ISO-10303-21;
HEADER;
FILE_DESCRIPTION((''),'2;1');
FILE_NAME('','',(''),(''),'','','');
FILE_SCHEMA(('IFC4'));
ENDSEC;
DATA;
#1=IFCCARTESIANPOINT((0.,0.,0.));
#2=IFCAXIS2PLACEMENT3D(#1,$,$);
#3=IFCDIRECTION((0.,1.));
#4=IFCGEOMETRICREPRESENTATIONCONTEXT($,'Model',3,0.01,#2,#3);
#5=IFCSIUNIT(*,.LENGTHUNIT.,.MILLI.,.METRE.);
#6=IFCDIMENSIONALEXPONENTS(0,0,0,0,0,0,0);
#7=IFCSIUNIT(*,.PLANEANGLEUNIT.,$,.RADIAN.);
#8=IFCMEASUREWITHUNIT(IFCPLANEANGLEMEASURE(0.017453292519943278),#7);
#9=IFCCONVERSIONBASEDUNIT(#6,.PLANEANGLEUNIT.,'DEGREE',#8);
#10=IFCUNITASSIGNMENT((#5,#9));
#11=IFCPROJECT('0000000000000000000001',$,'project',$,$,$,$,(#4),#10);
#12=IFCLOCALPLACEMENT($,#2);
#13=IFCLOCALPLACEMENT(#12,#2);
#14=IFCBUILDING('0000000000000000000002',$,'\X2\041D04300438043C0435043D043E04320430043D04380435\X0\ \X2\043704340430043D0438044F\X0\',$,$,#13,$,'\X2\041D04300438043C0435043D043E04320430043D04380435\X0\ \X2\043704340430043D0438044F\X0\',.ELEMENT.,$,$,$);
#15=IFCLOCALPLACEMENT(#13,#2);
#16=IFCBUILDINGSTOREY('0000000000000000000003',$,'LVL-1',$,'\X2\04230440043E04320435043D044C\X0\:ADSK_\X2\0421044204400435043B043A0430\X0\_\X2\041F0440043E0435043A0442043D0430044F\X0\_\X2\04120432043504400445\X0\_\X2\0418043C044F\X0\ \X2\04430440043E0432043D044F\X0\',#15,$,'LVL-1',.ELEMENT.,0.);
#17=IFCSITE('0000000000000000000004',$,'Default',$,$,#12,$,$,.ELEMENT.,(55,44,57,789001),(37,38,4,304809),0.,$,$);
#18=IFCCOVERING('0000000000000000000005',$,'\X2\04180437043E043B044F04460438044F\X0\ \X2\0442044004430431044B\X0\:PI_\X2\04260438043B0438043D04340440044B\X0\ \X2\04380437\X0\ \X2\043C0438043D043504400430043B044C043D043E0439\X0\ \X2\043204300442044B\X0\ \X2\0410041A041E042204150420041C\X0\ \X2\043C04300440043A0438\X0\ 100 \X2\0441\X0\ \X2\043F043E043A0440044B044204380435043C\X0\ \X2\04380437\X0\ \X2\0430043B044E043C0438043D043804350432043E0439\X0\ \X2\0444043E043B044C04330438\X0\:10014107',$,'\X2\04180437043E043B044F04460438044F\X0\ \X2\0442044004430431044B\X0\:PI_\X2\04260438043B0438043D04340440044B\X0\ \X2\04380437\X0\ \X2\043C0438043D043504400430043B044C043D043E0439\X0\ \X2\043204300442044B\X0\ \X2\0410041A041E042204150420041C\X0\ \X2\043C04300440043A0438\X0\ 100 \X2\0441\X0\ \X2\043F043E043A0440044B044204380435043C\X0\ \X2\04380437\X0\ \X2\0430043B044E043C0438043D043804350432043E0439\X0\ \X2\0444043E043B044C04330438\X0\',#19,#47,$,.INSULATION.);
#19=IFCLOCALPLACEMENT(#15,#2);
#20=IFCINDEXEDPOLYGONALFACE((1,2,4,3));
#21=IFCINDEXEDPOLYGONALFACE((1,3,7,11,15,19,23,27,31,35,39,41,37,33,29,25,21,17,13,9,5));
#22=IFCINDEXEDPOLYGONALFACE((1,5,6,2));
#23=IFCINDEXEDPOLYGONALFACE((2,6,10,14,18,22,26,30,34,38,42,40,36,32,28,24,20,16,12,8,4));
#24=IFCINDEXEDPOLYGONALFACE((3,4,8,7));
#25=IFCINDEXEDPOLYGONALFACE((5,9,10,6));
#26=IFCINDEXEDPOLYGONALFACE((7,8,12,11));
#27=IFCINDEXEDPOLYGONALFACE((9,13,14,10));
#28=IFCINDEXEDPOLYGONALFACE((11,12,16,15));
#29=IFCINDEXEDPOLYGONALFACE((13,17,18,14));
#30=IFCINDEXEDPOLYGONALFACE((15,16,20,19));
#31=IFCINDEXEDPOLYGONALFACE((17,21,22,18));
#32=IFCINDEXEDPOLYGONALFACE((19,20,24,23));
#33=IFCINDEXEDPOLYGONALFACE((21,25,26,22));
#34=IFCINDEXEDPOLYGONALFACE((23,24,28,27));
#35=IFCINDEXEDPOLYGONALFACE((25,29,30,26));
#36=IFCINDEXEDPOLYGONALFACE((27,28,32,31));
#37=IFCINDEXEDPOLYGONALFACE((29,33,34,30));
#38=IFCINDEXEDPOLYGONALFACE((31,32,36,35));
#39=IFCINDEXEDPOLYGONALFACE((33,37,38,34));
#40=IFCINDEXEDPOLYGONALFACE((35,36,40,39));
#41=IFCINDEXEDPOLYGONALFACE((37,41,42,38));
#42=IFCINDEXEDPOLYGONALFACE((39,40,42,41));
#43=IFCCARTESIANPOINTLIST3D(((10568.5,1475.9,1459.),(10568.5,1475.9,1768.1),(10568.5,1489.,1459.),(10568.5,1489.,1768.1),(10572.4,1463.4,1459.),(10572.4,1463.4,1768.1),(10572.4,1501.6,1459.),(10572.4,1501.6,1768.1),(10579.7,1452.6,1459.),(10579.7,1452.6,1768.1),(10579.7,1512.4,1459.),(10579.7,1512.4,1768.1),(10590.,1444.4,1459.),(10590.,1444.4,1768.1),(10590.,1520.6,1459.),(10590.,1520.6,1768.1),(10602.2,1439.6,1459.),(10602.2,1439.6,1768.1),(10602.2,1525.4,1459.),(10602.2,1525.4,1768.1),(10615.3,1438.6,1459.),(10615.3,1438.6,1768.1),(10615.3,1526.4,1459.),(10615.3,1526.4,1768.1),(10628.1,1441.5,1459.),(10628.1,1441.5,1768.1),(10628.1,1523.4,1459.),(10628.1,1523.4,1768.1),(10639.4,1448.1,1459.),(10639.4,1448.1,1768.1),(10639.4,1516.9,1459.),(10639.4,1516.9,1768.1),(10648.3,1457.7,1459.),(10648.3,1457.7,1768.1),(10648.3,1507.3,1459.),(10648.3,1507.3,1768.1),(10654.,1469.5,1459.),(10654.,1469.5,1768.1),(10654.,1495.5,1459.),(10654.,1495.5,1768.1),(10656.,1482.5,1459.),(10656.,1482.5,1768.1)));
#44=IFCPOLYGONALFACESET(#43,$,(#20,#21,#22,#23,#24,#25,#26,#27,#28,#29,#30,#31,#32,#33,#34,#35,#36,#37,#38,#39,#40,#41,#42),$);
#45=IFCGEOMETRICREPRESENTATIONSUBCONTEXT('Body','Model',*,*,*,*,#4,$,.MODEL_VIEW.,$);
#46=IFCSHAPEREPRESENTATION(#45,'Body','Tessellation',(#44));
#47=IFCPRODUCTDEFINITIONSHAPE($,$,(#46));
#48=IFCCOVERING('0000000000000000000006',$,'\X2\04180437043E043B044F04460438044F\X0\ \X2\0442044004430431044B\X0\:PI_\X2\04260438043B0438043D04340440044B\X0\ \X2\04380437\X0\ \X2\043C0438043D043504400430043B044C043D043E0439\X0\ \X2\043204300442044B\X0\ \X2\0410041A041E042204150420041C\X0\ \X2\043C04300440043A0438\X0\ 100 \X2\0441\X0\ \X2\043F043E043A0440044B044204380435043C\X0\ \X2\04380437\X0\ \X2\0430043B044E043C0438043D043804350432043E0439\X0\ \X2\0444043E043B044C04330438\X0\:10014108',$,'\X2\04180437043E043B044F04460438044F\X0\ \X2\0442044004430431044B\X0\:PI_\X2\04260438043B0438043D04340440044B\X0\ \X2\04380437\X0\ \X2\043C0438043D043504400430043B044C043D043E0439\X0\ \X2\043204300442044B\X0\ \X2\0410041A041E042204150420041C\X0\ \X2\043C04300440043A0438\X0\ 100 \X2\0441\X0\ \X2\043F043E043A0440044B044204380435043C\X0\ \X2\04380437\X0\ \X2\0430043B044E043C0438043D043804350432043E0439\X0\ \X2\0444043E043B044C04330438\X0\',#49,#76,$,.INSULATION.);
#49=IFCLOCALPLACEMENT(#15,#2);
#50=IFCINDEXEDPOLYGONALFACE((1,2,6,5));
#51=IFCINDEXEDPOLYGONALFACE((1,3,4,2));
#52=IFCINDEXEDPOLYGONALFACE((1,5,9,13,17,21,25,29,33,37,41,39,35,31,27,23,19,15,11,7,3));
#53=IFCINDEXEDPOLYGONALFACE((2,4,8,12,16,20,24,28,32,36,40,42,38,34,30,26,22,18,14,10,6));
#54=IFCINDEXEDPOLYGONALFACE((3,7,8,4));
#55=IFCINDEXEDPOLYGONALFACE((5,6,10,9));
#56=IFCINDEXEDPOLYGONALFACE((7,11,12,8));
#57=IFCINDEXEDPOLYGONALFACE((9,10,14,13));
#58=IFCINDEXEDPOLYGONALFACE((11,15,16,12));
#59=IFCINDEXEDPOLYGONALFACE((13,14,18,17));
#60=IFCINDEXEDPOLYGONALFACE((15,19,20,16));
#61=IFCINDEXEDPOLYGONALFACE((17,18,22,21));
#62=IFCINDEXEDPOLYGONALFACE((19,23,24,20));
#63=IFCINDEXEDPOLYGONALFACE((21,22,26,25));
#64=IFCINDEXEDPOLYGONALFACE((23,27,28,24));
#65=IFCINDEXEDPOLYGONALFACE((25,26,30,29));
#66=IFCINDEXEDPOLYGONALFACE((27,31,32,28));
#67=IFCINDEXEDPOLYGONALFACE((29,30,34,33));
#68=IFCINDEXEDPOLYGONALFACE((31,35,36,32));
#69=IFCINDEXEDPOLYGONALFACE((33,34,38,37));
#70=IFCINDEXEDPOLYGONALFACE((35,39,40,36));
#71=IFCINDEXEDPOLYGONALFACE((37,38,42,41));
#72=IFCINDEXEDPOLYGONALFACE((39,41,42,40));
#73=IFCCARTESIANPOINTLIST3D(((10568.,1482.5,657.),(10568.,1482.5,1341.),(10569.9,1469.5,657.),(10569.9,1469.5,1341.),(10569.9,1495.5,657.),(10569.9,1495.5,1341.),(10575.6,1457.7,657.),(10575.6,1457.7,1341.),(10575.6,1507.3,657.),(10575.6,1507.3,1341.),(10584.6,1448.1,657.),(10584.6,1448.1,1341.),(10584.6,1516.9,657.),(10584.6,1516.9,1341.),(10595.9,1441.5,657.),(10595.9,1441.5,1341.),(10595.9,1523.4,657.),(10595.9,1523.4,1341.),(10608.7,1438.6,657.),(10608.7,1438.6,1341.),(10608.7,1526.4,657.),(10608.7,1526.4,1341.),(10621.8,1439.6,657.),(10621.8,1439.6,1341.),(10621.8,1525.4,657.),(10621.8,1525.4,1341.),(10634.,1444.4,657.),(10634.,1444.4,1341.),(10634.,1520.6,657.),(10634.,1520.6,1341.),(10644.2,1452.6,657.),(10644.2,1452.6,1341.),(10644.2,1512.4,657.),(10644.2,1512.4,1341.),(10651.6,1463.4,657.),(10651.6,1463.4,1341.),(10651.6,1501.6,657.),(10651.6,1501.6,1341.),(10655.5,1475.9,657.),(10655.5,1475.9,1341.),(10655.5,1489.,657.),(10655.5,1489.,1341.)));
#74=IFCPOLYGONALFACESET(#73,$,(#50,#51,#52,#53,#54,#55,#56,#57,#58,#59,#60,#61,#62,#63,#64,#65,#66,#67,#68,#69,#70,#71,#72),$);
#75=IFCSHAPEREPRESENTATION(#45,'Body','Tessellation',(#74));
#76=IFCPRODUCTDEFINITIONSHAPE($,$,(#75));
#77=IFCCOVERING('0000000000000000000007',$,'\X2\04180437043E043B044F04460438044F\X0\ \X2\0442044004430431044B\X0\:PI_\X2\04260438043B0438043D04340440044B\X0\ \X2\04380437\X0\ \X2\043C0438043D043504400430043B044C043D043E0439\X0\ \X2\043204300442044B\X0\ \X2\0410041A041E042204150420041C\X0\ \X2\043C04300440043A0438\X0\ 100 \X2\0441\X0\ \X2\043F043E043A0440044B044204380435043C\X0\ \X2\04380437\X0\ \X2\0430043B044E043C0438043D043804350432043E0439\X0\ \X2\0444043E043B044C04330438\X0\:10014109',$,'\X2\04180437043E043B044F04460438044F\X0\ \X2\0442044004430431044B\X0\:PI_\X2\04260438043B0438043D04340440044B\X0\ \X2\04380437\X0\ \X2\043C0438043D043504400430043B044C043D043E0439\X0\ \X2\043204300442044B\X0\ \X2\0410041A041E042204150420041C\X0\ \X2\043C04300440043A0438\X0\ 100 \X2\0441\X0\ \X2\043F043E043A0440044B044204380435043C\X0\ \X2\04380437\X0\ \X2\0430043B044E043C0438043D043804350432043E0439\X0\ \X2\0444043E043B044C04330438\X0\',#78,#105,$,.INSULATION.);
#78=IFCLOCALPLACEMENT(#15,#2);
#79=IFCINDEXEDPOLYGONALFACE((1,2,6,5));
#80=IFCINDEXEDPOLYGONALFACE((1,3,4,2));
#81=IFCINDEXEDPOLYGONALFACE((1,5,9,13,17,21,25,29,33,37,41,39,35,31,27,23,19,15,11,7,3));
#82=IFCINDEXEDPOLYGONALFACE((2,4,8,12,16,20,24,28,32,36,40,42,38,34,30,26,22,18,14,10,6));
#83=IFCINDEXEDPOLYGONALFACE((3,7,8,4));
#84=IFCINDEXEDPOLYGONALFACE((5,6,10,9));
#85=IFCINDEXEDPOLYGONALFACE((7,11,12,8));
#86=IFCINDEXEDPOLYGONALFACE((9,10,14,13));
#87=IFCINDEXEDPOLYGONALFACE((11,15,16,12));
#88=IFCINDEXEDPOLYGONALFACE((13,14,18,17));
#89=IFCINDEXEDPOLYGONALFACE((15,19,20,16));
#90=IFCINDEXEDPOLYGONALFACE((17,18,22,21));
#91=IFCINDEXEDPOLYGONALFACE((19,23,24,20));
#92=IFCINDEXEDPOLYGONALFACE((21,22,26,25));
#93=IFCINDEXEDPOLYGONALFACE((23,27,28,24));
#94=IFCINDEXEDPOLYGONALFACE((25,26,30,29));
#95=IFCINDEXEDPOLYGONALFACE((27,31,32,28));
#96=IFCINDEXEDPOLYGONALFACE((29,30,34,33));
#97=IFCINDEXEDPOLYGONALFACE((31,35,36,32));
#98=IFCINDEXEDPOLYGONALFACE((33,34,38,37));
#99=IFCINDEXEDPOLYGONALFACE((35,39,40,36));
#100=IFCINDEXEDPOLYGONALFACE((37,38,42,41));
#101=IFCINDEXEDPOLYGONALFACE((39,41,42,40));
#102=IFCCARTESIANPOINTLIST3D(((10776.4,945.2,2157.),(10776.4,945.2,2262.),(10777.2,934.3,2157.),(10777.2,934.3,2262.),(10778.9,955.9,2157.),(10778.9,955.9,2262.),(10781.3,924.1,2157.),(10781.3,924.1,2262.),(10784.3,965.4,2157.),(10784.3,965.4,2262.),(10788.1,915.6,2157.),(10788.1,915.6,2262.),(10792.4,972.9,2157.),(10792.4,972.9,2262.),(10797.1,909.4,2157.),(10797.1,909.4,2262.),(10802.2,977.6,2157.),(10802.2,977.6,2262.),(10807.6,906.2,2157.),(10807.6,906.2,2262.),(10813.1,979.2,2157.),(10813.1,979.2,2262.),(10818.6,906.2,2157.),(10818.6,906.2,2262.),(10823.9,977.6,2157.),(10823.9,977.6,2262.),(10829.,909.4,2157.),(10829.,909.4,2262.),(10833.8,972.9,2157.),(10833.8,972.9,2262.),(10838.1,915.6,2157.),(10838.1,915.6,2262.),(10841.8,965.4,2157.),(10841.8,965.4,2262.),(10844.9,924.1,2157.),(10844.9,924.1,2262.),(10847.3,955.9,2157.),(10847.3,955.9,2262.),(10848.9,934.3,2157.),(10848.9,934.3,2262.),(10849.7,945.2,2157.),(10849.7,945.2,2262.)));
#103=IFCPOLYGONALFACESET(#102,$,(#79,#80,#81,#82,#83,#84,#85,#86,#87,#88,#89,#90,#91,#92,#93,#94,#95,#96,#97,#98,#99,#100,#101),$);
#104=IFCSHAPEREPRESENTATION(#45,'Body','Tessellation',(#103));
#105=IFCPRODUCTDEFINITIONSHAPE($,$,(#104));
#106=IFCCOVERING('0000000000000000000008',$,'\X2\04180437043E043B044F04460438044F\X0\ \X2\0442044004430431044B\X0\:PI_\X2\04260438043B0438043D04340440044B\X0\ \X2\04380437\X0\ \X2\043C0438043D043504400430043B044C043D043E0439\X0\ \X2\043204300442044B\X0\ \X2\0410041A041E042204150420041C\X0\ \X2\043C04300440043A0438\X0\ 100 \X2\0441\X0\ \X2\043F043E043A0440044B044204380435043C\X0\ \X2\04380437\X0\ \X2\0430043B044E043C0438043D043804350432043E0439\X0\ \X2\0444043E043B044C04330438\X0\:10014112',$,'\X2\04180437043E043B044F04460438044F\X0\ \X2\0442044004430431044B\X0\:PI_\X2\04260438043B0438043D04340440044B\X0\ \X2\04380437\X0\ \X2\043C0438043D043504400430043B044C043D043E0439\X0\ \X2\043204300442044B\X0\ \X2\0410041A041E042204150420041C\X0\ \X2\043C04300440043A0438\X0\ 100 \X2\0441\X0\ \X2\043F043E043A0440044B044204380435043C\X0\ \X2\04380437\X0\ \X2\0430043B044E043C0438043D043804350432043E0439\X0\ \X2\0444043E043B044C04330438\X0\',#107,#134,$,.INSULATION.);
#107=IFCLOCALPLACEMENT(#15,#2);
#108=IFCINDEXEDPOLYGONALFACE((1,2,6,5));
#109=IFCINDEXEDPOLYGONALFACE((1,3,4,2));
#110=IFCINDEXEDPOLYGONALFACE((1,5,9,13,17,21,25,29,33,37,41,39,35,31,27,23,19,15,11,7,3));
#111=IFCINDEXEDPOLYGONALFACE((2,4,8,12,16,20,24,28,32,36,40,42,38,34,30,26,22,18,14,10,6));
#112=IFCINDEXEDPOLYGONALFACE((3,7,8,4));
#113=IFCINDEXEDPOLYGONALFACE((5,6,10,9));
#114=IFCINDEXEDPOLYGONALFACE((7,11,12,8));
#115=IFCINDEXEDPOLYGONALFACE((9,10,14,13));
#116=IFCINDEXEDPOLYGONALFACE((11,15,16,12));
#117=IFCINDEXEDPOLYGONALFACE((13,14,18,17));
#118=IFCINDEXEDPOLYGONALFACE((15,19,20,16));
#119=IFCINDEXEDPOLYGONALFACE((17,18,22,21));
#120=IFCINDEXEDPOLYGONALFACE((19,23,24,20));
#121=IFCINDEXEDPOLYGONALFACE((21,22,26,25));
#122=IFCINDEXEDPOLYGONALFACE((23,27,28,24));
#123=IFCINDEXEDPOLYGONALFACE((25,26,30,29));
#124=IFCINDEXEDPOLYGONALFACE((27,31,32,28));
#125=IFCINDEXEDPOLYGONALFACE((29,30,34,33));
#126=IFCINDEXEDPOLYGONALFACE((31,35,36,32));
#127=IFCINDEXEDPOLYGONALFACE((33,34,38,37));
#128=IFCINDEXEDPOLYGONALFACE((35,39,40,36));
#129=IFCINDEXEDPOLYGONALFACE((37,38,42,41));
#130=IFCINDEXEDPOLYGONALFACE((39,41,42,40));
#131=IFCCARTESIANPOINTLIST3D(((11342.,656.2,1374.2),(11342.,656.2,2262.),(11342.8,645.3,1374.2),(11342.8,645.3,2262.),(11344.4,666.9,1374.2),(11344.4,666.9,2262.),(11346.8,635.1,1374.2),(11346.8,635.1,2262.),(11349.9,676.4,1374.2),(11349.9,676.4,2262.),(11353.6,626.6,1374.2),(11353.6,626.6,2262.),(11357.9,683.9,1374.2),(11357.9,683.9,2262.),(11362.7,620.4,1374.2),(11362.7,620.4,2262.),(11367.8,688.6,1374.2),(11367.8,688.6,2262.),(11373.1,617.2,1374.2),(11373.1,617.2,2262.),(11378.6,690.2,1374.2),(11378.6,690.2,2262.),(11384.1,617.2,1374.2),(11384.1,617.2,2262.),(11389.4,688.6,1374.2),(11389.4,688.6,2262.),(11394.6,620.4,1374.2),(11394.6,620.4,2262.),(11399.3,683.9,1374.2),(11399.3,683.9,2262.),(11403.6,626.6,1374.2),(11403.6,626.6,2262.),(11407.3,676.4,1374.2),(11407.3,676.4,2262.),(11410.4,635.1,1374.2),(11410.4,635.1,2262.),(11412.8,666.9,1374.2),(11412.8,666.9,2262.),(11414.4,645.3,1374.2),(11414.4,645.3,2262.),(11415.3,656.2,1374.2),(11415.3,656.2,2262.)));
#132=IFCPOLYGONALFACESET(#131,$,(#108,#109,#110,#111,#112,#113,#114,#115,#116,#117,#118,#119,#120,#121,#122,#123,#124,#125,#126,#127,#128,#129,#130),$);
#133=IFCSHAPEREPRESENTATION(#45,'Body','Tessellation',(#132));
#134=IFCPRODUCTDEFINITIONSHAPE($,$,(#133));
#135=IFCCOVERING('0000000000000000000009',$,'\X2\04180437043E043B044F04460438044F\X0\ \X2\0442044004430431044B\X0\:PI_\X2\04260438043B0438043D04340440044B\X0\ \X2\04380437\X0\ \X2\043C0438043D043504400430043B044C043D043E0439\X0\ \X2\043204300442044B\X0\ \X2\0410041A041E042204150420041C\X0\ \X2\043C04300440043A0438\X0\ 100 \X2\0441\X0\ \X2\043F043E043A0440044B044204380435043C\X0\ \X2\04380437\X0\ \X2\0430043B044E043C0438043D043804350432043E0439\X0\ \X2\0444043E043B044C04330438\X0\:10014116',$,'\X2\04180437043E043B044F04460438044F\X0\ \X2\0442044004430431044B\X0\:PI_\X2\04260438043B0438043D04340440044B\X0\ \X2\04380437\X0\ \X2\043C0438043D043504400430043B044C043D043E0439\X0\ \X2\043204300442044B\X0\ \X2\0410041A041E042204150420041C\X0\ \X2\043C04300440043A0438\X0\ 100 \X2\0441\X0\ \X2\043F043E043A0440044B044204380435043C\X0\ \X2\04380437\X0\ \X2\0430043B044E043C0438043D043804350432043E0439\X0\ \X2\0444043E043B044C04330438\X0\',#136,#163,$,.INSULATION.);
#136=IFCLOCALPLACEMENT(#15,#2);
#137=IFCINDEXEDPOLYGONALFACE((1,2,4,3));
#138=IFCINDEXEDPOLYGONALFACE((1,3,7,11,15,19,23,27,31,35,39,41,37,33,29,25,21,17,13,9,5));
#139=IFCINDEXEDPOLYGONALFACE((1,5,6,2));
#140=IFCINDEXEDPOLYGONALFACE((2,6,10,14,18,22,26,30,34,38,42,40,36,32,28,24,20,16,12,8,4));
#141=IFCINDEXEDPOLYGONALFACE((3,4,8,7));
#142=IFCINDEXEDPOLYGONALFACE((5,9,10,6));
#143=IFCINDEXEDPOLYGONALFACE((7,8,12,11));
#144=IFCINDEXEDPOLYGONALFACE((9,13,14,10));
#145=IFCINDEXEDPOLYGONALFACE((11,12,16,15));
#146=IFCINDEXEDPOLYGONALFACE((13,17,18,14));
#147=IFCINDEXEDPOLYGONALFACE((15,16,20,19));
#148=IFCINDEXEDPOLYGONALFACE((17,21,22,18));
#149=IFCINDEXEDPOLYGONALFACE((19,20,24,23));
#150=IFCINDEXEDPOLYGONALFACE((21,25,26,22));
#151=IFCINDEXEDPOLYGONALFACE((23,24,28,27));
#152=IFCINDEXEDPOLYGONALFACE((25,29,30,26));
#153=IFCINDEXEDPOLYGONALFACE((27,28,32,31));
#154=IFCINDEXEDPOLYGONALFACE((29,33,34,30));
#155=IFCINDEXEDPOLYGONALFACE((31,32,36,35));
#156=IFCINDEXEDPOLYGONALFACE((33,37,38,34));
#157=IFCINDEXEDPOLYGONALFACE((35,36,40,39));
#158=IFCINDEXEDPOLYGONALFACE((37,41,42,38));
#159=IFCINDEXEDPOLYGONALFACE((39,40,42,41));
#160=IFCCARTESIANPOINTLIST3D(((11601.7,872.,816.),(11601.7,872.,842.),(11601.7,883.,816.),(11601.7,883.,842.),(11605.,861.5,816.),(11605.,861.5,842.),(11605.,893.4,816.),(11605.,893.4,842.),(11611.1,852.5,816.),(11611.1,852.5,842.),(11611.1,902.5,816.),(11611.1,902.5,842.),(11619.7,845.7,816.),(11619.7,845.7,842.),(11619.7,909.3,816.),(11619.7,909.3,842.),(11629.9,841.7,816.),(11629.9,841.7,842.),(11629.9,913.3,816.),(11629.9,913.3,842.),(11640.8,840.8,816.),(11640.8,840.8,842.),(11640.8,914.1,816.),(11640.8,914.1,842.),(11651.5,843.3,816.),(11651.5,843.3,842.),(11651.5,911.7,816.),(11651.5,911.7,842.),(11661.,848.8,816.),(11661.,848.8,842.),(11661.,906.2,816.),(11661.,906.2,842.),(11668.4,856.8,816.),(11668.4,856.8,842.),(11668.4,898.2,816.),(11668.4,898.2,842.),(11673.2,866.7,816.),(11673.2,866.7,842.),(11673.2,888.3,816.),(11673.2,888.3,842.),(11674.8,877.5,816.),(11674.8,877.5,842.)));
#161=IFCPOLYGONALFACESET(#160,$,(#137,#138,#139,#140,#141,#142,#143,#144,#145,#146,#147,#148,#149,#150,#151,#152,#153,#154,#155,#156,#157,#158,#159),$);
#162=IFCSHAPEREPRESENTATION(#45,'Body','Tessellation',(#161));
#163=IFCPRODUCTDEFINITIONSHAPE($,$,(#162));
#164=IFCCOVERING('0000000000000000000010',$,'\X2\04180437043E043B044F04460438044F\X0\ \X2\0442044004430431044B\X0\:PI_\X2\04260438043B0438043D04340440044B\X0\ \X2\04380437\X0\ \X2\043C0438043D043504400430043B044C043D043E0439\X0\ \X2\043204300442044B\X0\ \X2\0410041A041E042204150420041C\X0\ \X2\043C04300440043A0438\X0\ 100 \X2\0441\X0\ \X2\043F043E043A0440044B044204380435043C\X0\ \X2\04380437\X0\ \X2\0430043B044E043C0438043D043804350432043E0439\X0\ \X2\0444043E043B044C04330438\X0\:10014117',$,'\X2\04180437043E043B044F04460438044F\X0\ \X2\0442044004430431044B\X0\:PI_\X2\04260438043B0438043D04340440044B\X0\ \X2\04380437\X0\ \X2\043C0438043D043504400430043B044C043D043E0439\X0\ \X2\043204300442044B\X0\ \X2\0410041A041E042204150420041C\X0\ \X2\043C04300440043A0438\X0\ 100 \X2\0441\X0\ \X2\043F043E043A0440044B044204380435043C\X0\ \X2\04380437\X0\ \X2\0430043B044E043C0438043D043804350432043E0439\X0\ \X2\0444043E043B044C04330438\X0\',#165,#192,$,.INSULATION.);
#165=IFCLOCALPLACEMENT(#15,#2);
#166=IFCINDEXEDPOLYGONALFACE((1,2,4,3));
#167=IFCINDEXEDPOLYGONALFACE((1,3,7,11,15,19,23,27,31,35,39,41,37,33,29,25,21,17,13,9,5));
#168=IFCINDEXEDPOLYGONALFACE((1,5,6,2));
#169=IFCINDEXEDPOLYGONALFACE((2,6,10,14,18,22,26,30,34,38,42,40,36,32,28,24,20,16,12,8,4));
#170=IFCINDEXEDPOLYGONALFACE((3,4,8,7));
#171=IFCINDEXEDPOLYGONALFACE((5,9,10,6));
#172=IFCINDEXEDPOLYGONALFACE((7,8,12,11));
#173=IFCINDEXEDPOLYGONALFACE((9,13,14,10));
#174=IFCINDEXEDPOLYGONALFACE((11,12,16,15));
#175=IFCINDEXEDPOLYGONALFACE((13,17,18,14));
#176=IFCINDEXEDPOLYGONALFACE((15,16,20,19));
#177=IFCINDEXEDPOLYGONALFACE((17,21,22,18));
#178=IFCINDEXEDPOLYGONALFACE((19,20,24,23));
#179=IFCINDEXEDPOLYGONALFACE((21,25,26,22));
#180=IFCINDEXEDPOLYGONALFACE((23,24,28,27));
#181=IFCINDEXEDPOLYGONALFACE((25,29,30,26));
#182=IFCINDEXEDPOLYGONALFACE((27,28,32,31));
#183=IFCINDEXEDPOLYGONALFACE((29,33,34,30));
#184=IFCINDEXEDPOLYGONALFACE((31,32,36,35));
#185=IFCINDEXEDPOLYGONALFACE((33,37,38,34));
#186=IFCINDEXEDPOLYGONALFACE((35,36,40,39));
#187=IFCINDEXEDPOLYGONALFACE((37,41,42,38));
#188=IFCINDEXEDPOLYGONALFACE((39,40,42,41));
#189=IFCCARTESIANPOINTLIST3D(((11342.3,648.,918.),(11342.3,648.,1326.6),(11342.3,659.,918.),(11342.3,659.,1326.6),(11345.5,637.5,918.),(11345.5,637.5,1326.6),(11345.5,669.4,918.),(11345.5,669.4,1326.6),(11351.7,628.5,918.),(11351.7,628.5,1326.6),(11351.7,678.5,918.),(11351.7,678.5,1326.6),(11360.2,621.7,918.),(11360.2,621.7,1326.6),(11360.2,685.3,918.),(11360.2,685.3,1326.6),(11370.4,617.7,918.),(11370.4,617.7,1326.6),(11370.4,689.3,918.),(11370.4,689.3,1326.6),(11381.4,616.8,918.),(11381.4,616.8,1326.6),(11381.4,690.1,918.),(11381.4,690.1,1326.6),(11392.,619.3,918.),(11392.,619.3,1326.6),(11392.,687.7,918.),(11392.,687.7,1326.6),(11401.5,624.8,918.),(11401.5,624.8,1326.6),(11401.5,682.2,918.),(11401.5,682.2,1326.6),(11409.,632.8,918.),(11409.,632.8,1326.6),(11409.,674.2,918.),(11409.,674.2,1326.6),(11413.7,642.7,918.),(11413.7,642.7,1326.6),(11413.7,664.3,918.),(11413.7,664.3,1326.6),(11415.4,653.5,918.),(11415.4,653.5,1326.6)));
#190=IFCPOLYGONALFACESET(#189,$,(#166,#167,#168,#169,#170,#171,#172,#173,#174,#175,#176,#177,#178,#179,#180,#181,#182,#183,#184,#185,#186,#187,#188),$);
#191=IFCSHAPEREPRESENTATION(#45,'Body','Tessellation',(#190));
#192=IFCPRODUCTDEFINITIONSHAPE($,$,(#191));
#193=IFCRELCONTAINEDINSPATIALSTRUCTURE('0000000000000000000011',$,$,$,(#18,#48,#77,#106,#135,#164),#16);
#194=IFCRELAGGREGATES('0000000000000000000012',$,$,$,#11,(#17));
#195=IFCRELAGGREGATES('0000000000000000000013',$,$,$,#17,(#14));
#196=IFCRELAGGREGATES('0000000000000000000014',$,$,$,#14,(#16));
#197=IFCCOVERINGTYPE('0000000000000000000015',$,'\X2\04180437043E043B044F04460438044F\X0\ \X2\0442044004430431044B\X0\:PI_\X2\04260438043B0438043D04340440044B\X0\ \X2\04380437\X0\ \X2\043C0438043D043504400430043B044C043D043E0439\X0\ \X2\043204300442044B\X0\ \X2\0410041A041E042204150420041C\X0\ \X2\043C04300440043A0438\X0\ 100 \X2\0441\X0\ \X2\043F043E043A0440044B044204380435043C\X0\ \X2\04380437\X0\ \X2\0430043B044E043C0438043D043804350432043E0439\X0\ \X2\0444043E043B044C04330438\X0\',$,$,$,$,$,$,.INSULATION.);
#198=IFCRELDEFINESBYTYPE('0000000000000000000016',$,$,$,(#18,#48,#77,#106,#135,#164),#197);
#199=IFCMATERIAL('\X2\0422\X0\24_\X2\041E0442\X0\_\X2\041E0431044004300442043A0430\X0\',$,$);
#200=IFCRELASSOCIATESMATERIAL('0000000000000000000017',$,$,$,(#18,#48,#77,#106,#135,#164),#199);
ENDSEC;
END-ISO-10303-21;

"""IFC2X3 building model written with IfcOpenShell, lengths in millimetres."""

from ifc_helpers import new_model, entity, si_unit, converted_unit, direction, frame, frame_2d, origin, origin_2d_with_axis, place, context, subcontext, project, spatial, circle, extrude, material, type_object, element, save


model = new_model("IFC2X3")

# Units and contexts
model_context = context("Model", 3, precision=0.01, world=origin(), true_north=direction((0.0, 1.0)))
body_context = subcontext(model_context, "Body", "Model", "MODEL_VIEW")
ifc_project = project(units=[si_unit("LENGTHUNIT", "METRE", prefix="MILLI"), converted_unit("PLANEANGLEUNIT", "DEGREE", entity("IfcPlaneAngleMeasure", 0.017453292519943278), si_unit("PLANEANGLEUNIT", "RADIAN"), dimensions=[0, 0, 0, 0, 0, 0, 0])], contexts=[model_context])

# Site, building, storey
site_placement = place(None, origin())
site = spatial("IfcSite", under=ifc_project, at=site_placement, Name="Default", CompositionType="ELEMENT", RefLatitude=(55, 44, 57, 789001), RefLongitude=(37, 38, 4, 304809), RefElevation=0.0)
building_placement = place(site_placement, origin())
building = spatial("IfcBuilding", under=site, at=building_placement, Name="Наименование здания", LongName="Наименование здания", CompositionType="ELEMENT")
storey_placement = place(building_placement, origin())
storey = spatial("IfcBuildingStorey", under=building, at=storey_placement, Name="LVL-1", ObjectType="Уровень:ADSK_Стрелка_Проектная_Вверх_Имя уровня", LongName="LVL-1", CompositionType="ELEMENT", Elevation=0.0)

# Coverings
covering_type = type_object("IfcCoveringType", Name="Изоляция трубы:PI_Цилиндры из минеральной ваты АКОТЕРМ марки 100 с покрытием из алюминиевой фольги", PredefinedType="INSULATION")
ifc_material_1 = material(Name="Т24_От_Обратка")
covering_1_placement = place(storey_placement, origin())
element("IfcCovering", 1, at=covering_1_placement, inside=storey, type_object=covering_type, material=ifc_material_1, Name="Изоляция трубы:PI_Цилиндры из минеральной ваты АКОТЕРМ марки 100 с покрытием из алюминиевой фольги:10014107", ObjectType="Изоляция трубы:PI_Цилиндры из минеральной ваты АКОТЕРМ марки 100 с покрытием из алюминиевой фольги", PredefinedType="INSULATION", context=body_context, shape_type="SweptSolid", body=[
    extrude(circle(Radius=44.0, at=frame_2d((0.0, 0.0), x_axis=(1.0, 0.0))), frame((10612.0, 1482.5, 1459.0)), (0.0, 0.0, 1.0), 309.1),
])
covering_2_placement = place(storey_placement, origin())
element("IfcCovering", 2, at=covering_2_placement, inside=storey, type_object=covering_type, material=ifc_material_1, Name="Изоляция трубы:PI_Цилиндры из минеральной ваты АКОТЕРМ марки 100 с покрытием из алюминиевой фольги:10014108", ObjectType="Изоляция трубы:PI_Цилиндры из минеральной ваты АКОТЕРМ марки 100 с покрытием из алюминиевой фольги", PredefinedType="INSULATION", context=body_context, shape_type="SweptSolid", body=[
    extrude(circle(Radius=44.0, at=frame_2d((0.0, 0.0), x_axis=(1.0, 0.0))), frame((10612.0, 1482.5, 657.0), z_axis=(0.0, 0.0, 1.0), x_axis=(-1.0, 0.0, 0.0)), (0.0, 0.0, 1.0), 684.0),
])
covering_3_placement = place(storey_placement, origin())
element("IfcCovering", 3, at=covering_3_placement, inside=storey, type_object=covering_type, material=ifc_material_1, Name="Изоляция трубы:PI_Цилиндры из минеральной ваты АКОТЕРМ марки 100 с покрытием из алюминиевой фольги:10014109", ObjectType="Изоляция трубы:PI_Цилиндры из минеральной ваты АКОТЕРМ марки 100 с покрытием из алюминиевой фольги", PredefinedType="INSULATION", context=body_context, shape_type="SweptSolid", body=[
    extrude(circle(Radius=36.8, at=frame_2d((0.0, 0.0), x_axis=(1.0, 0.0))), frame((10813.1, 942.5, 2157.0), z_axis=(0.0, 0.0, 1.0), x_axis=(0.0, 1.0, 0.0)), (0.0, 0.0, 1.0), 105.0),
])
covering_4_placement = place(storey_placement, origin())
element("IfcCovering", 4, at=covering_4_placement, inside=storey, type_object=covering_type, material=ifc_material_1, Name="Изоляция трубы:PI_Цилиндры из минеральной ваты АКОТЕРМ марки 100 с покрытием из алюминиевой фольги:10014112", ObjectType="Изоляция трубы:PI_Цилиндры из минеральной ваты АКОТЕРМ марки 100 с покрытием из алюминиевой фольги", PredefinedType="INSULATION", context=body_context, shape_type="SweptSolid", body=[
    extrude(circle(Radius=36.8, at=frame_2d((0.0, 0.0), x_axis=(1.0, 0.0))), frame((11378.6, 653.5, 1374.2), z_axis=(0.0, 0.0, 1.0), x_axis=(0.0, 1.0, 0.0)), (0.0, 0.0, 1.0), 887.7),
])
covering_5_placement = place(storey_placement, origin())
element("IfcCovering", 5, at=covering_5_placement, inside=storey, type_object=covering_type, material=ifc_material_1, Name="Изоляция трубы:PI_Цилиндры из минеральной ваты АКОТЕРМ марки 100 с покрытием из алюминиевой фольги:10014116", ObjectType="Изоляция трубы:PI_Цилиндры из минеральной ваты АКОТЕРМ марки 100 с покрытием из алюминиевой фольги", PredefinedType="INSULATION", context=body_context, shape_type="SweptSolid", body=[
    extrude(circle(Radius=36.8, at=origin_2d_with_axis()), frame((11638.1, 877.5, 816.0)), (0.0, 0.0, 1.0), 26.0),
])
covering_6_placement = place(storey_placement, origin())
element("IfcCovering", 6, at=covering_6_placement, inside=storey, type_object=covering_type, material=ifc_material_1, Name="Изоляция трубы:PI_Цилиндры из минеральной ваты АКОТЕРМ марки 100 с покрытием из алюминиевой фольги:10014117", ObjectType="Изоляция трубы:PI_Цилиндры из минеральной ваты АКОТЕРМ марки 100 с покрытием из алюминиевой фольги", PredefinedType="INSULATION", context=body_context, shape_type="SweptSolid", body=[
    extrude(circle(Radius=36.8, at=origin_2d_with_axis()), frame((11378.6, 653.5, 918.0)), (0.0, 0.0, 1.0), 408.6),
])

save(model, "model.ifc")
